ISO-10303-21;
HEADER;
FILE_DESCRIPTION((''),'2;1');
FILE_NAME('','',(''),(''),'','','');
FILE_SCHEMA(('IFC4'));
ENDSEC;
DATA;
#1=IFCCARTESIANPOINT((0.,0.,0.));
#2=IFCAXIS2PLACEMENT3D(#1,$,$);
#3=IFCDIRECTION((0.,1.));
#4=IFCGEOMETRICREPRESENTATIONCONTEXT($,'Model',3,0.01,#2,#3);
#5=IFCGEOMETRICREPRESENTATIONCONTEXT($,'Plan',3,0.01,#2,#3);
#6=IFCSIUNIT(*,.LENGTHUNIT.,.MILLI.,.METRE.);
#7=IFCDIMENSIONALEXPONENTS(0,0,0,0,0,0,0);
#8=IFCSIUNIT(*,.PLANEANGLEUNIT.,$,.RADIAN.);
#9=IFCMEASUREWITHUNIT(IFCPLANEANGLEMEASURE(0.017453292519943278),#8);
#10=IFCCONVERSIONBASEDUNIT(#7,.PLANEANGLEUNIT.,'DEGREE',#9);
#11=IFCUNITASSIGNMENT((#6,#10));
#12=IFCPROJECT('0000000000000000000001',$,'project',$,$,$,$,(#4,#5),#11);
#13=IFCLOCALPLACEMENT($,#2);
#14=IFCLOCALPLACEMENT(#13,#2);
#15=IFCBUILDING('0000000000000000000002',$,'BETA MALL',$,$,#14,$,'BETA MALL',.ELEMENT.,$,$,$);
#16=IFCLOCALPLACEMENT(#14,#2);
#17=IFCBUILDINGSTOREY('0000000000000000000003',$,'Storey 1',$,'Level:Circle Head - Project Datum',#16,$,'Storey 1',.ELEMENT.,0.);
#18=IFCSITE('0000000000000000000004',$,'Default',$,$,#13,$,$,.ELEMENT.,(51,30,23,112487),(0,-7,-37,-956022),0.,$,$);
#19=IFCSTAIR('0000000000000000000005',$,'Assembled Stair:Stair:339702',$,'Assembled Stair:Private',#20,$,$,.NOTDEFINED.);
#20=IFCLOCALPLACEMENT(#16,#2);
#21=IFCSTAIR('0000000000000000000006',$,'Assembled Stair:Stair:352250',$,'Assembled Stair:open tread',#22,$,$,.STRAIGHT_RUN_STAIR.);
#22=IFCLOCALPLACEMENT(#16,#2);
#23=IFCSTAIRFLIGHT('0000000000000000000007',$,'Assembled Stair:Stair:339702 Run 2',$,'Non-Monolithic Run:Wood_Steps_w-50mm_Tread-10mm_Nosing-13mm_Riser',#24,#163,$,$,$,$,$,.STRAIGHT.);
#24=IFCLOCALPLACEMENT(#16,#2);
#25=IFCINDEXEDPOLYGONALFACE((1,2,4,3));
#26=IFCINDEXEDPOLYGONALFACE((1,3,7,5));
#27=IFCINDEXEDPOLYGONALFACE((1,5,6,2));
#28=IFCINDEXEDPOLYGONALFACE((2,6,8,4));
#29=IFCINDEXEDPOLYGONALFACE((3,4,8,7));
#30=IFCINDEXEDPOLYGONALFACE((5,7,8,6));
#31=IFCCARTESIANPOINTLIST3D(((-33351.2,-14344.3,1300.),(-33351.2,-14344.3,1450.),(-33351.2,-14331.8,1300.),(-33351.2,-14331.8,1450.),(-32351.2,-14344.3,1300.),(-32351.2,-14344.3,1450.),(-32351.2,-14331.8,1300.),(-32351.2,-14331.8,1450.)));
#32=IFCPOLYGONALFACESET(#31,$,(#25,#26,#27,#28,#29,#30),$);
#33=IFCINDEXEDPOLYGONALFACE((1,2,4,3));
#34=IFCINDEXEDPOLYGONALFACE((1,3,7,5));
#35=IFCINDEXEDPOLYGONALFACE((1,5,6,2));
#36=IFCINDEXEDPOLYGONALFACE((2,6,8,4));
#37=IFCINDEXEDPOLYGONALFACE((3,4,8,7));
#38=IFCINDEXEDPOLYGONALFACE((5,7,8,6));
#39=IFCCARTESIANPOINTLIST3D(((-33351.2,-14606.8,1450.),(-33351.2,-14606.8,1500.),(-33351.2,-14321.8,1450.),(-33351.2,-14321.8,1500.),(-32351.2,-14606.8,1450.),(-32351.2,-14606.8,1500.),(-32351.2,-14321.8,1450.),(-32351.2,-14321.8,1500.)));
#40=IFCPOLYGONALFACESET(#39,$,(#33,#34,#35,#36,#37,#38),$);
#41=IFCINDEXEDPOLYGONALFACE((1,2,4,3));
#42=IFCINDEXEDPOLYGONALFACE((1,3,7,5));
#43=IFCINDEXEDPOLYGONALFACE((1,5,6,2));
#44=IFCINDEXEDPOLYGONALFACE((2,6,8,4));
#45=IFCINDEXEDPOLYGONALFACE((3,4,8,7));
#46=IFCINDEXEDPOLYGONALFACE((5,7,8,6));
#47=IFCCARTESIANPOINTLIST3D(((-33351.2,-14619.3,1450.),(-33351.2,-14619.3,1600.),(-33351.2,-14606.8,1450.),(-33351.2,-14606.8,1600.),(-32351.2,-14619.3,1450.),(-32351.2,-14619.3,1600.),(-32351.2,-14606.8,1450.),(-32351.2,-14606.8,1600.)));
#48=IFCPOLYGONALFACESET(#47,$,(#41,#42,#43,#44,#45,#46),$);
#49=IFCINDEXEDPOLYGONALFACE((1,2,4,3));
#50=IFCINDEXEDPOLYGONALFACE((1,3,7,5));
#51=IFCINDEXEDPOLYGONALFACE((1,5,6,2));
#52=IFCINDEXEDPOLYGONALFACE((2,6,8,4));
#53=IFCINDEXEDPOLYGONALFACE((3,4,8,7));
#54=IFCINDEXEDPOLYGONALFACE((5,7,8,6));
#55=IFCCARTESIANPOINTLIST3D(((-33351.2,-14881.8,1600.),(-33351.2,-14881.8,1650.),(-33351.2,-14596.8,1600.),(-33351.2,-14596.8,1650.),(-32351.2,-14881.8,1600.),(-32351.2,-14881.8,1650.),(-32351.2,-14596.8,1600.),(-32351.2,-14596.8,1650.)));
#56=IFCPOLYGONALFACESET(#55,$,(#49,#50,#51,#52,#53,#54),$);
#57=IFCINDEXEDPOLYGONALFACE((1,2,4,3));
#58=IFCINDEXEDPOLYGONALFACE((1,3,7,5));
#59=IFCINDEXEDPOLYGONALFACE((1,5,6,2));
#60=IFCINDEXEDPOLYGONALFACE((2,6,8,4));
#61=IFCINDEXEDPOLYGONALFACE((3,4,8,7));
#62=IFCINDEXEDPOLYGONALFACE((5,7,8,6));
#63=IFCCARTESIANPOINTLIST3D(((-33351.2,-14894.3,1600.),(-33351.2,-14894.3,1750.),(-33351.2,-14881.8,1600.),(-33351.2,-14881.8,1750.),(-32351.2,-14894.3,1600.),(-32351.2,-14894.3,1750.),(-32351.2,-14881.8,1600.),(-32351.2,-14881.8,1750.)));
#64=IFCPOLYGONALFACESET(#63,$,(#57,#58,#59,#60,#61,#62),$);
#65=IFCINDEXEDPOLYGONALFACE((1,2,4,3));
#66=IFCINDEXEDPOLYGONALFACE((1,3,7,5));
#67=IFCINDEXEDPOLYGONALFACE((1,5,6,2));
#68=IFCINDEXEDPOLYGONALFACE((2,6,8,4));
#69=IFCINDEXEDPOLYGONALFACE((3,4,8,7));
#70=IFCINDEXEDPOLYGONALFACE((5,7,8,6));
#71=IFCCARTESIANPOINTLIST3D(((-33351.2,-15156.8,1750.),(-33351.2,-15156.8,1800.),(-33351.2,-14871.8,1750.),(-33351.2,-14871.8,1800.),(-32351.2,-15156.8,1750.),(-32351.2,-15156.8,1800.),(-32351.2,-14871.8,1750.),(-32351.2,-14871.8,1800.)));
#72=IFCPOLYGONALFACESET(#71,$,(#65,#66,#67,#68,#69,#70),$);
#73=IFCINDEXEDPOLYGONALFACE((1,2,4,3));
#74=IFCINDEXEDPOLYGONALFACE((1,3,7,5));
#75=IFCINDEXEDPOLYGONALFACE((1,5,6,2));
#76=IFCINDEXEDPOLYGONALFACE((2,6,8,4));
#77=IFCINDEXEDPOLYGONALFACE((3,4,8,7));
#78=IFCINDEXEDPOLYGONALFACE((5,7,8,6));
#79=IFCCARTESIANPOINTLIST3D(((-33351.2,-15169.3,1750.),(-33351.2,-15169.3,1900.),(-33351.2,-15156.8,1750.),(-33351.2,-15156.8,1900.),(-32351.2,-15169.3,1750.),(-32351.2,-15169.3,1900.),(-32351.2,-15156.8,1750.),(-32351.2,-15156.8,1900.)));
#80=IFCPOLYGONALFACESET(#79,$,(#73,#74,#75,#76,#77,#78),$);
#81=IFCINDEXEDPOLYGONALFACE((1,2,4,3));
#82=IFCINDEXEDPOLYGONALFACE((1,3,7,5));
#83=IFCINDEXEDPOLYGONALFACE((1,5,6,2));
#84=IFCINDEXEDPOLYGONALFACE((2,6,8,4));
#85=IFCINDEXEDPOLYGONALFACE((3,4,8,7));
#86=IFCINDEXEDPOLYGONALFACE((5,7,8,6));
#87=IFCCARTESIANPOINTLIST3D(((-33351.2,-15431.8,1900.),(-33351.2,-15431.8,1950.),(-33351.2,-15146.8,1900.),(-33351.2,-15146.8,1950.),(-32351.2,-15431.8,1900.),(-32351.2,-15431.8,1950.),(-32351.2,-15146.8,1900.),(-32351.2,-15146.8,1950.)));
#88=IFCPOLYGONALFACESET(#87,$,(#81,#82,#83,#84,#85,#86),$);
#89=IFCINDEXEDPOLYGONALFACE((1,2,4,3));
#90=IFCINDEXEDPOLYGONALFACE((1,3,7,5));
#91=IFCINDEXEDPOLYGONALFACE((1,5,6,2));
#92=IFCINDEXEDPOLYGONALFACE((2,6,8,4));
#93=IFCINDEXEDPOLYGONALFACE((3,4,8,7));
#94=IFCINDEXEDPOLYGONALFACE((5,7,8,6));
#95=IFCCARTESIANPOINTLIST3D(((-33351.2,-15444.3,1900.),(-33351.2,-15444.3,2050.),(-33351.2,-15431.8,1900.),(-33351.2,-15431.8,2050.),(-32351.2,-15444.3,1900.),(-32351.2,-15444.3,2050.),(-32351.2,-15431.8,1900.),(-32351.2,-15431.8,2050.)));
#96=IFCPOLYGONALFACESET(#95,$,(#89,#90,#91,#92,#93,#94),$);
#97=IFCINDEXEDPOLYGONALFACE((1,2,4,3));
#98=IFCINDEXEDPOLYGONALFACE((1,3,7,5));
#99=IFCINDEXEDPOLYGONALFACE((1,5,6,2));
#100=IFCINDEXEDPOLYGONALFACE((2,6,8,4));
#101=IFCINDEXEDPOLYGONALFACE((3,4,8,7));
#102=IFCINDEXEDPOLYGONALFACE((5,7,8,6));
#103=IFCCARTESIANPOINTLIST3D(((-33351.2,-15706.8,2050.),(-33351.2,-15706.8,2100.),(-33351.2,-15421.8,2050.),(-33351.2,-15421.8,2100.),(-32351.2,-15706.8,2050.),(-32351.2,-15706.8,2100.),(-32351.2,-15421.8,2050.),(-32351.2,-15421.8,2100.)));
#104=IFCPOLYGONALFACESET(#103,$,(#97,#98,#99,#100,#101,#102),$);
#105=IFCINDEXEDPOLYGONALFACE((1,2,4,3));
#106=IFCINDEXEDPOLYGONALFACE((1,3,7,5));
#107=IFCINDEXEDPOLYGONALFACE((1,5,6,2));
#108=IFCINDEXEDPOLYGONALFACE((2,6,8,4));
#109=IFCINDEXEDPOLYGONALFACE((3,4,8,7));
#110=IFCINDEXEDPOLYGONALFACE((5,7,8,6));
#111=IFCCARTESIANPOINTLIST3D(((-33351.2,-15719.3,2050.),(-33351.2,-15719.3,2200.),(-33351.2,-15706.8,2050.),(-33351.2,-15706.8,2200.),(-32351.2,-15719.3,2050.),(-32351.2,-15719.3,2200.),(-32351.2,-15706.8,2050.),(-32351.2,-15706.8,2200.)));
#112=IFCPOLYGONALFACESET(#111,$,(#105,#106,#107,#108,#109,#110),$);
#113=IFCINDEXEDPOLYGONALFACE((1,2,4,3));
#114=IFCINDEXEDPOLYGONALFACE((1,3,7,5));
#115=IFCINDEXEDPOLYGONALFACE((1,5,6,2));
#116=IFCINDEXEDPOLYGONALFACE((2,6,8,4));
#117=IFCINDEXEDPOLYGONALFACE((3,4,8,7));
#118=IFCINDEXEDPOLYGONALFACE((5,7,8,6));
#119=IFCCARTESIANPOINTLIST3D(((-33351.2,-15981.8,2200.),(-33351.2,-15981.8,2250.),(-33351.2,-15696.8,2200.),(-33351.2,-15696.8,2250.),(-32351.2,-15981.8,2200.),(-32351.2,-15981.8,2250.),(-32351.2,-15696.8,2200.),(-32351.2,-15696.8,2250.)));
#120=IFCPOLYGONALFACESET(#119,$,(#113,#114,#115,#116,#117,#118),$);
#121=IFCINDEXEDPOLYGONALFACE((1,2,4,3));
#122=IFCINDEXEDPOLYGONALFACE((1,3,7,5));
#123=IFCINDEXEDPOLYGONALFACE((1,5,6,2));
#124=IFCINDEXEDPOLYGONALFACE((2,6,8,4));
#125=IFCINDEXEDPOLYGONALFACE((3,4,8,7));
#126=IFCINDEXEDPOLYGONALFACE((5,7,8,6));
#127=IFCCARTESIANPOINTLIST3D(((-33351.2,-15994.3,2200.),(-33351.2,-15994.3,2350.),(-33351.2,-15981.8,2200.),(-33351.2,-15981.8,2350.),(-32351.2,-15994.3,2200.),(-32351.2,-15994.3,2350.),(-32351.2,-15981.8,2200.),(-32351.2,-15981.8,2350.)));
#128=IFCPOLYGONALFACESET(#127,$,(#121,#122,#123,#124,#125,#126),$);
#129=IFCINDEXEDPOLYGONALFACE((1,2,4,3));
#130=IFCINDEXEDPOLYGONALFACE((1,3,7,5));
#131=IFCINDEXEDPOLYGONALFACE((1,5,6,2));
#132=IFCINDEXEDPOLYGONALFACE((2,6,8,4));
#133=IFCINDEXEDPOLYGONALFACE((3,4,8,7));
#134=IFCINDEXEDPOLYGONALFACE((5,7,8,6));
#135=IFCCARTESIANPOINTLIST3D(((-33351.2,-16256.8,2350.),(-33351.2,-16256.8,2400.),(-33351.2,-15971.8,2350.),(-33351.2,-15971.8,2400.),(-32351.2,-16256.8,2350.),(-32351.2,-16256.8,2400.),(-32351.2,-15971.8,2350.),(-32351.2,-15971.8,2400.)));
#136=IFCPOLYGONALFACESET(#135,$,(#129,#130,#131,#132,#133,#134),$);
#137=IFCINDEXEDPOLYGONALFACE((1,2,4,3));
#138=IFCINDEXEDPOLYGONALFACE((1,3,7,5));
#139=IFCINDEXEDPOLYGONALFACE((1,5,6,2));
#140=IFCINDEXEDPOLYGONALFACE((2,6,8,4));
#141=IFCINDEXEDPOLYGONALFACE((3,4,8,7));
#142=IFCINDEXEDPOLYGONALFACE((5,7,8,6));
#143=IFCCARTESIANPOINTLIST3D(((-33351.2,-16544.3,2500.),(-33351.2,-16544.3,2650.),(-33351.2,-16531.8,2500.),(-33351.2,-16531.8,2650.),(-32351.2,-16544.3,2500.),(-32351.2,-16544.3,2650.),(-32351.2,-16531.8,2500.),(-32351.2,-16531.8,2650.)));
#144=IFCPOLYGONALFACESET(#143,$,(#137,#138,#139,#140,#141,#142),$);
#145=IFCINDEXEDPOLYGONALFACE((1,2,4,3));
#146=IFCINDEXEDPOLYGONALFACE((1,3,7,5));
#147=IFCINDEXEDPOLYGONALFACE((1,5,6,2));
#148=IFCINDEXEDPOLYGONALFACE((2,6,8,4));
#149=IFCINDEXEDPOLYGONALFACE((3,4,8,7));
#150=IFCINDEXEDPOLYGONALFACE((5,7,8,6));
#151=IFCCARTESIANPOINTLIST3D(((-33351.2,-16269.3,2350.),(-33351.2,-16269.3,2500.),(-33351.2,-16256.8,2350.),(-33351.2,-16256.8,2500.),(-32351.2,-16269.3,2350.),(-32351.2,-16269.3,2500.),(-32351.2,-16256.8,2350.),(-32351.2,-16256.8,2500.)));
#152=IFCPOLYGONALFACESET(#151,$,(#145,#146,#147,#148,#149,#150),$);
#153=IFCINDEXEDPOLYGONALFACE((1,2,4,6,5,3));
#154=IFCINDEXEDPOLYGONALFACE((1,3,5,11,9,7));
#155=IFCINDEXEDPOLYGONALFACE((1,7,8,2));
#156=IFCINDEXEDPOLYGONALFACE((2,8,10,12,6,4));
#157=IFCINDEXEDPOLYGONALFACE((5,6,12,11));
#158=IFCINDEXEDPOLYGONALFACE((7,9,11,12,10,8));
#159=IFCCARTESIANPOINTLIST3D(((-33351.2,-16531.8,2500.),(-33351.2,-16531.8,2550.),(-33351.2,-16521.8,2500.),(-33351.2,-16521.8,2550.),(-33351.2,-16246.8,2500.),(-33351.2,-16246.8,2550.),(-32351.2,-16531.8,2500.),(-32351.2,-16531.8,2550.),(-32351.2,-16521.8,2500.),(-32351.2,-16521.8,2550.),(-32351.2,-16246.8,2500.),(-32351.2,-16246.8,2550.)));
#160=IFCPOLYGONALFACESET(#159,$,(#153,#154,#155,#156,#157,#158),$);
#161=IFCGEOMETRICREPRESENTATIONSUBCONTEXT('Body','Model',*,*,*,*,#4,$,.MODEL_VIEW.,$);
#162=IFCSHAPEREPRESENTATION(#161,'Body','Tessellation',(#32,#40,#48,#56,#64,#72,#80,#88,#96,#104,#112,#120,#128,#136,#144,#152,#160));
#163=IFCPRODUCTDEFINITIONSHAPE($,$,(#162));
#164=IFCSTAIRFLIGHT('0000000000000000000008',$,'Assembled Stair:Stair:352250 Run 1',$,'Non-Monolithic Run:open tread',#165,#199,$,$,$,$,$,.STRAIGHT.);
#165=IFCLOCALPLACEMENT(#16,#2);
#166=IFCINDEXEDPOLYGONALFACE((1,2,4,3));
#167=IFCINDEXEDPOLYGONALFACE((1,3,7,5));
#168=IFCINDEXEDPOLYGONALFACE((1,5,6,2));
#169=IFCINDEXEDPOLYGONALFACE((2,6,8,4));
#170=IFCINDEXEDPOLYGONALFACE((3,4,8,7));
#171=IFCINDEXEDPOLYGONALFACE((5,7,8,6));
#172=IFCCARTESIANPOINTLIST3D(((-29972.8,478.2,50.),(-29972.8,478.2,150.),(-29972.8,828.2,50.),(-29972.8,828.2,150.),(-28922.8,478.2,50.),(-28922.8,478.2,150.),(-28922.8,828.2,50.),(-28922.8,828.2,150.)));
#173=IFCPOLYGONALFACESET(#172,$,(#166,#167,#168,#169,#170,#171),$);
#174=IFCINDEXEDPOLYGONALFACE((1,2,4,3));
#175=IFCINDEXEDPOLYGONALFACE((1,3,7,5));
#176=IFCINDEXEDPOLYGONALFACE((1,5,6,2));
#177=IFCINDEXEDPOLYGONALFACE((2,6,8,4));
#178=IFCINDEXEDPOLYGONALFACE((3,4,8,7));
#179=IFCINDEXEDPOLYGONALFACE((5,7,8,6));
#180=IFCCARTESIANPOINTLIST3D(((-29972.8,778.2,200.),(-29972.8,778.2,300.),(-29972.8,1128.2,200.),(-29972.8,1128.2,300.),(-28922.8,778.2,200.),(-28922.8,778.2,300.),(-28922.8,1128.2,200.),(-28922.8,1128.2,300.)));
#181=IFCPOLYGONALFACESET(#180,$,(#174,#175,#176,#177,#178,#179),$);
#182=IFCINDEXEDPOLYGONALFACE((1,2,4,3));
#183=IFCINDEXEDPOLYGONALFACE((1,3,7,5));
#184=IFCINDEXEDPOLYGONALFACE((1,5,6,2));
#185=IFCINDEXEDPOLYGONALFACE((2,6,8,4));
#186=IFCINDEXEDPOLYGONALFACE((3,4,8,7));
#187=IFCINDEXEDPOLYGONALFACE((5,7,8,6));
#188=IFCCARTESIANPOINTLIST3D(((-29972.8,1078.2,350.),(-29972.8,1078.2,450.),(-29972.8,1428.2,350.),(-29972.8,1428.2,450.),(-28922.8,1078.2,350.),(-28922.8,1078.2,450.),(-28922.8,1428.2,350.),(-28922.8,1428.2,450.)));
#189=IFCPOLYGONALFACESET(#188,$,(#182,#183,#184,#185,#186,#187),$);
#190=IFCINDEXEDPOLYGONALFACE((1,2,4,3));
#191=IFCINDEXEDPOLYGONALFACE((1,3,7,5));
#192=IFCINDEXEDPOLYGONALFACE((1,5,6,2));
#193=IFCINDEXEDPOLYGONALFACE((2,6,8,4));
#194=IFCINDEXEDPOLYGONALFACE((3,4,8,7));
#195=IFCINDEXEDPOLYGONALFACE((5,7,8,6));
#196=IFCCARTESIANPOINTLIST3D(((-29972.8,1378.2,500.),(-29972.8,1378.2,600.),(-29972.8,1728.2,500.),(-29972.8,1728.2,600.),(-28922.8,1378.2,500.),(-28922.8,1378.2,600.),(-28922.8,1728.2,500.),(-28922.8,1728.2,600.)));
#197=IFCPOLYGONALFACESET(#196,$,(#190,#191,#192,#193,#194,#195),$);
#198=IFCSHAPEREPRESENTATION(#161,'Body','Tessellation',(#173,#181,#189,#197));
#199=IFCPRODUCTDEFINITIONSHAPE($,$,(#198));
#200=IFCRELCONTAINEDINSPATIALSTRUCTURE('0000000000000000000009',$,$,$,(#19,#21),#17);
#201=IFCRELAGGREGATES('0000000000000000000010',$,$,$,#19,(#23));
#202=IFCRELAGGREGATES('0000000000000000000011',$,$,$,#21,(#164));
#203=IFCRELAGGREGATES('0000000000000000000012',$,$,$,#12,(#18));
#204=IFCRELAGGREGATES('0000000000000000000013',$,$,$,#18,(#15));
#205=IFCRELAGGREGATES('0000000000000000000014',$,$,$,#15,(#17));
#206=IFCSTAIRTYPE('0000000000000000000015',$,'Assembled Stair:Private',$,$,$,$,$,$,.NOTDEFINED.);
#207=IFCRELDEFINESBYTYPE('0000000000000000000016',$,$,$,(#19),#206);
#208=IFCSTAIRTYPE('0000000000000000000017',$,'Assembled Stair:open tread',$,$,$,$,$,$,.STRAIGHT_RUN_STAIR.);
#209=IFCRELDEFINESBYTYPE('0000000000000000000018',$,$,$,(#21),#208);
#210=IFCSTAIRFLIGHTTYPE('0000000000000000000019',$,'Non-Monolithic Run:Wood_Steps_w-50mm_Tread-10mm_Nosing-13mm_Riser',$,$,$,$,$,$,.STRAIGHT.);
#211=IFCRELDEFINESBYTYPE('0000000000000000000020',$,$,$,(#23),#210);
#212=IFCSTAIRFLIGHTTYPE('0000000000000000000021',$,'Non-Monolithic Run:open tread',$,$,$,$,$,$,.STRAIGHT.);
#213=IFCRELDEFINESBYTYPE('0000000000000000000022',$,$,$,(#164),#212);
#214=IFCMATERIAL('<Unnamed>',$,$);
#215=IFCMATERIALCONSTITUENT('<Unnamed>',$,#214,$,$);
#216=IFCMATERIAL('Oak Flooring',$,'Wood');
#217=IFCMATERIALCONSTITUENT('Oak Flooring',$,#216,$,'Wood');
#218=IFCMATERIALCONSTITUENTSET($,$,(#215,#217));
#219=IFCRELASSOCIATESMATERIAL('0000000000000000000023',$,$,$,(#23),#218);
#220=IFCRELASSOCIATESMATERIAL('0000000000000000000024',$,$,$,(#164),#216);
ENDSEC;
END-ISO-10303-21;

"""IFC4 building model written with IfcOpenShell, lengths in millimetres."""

from ifc_helpers import new_model, entity, si_unit, converted_unit, direction, frame, origin, place, context, subcontext, project, spatial, indexed_curve, outline, extrude, material, constituent, constituent_set, type_object, element, aggregate, save


model = new_model("IFC4")

# Units and contexts
model_context = context("Model", 3, precision=0.01, world=origin(), true_north=direction((0.0, 1.0)))
plan_context = context("Plan", 3, precision=0.01, world=origin(), true_north=direction((0.0, 1.0)))
body_context = subcontext(model_context, "Body", "Model", "MODEL_VIEW")
ifc_project = project(units=[si_unit("LENGTHUNIT", "METRE", prefix="MILLI"), converted_unit("PLANEANGLEUNIT", "DEGREE", entity("IfcPlaneAngleMeasure", 0.017453292519943278), si_unit("PLANEANGLEUNIT", "RADIAN"), dimensions=[0, 0, 0, 0, 0, 0, 0])], contexts=[model_context, plan_context])

# Site, building, storey
site_placement = place(None, origin())
site = spatial("IfcSite", under=ifc_project, at=site_placement, Name="Default", CompositionType="ELEMENT", RefLatitude=(51, 30, 23, 112487), RefLongitude=(0, -7, -37, -956022), RefElevation=0.0)
building_placement = place(site_placement, origin())
building = spatial("IfcBuilding", under=site, at=building_placement, Name="BETA MALL", LongName="BETA MALL", CompositionType="ELEMENT")
storey_placement = place(building_placement, origin())
storey = spatial("IfcBuildingStorey", under=building, at=storey_placement, Name="Storey 1", ObjectType="Level:Circle Head - Project Datum", LongName="Storey 1", CompositionType="ELEMENT", Elevation=0.0)

# Shared definitions
ifc_material_1 = material(Name="<Unnamed>")

# Stair
stair_type_1 = type_object("IfcStairType", Name="Assembled Stair:Private", PredefinedType="NOTDEFINED")
stair_1_placement = place(storey_placement, origin())
stair_1 = element("IfcStair", 1, at=stair_1_placement, inside=storey, type_object=stair_type_1, Name="Assembled Stair:Stair:339702", ObjectType="Assembled Stair:Private", PredefinedType="NOTDEFINED")
ifc_material_2 = material(Name="Oak Flooring", Category="Wood")

# Stair
stair_type_2 = type_object("IfcStairType", Name="Assembled Stair:open tread", PredefinedType="STRAIGHT_RUN_STAIR")
stair_2_placement = place(storey_placement, origin())
stair_2 = element("IfcStair", 2, at=stair_2_placement, inside=storey, type_object=stair_type_2, Name="Assembled Stair:Stair:352250", ObjectType="Assembled Stair:open tread", PredefinedType="STRAIGHT_RUN_STAIR")

# Stair flights
stair_flight_type_1 = type_object("IfcStairFlightType", Name="Non-Monolithic Run:Wood_Steps_w-50mm_Tread-10mm_Nosing-13mm_Riser", PredefinedType="STRAIGHT")
ifc_constituent_1 = constituent(ifc_material_1, Name="<Unnamed>")
ifc_constituent_2 = constituent(ifc_material_2, Name="Oak Flooring", Category="Wood")
ifc_constituent_set_1 = constituent_set(constituents=[ifc_constituent_1, ifc_constituent_2])
stair_flight_1_placement = place(stair_1_placement, origin())
stair_flight_1 = element("IfcStairFlight", 3, at=stair_flight_1_placement, type_object=stair_flight_type_1, material=ifc_constituent_set_1, Name="Assembled Stair:Stair:339702 Run 2", ObjectType="Non-Monolithic Run:Wood_Steps_w-50mm_Tread-10mm_Nosing-13mm_Riser", PredefinedType="STRAIGHT", context=body_context, shape_type="SweptSolid", body=[
    extrude(outline(indexed_curve([(-500.0, -6.2), (500.0, -6.2), (500.0, 6.3), (-500.0, 6.3), (-500.0, -6.2)], self_intersect=False)), frame((-32851.2, -14338.1, 1300.0)), (0.0, 0.0, 1.0), 150.0),
    extrude(outline(indexed_curve([(-142.5, -500.0), (142.5, -500.0), (142.5, 500.0), (-142.5, 500.0), (-142.5, -500.0)], self_intersect=False)), frame((-32851.2, -14464.3, 1450.0), z_axis=(0.0, 0.0, 1.0), x_axis=(0.0, 1.0, 0.0)), (0.0, 0.0, 1.0), 50.0),
    extrude(outline(indexed_curve([(-500.0, -6.3), (500.0, -6.3), (500.0, 6.2), (-500.0, 6.2), (-500.0, -6.3)], self_intersect=False)), frame((-32851.2, -14613.1, 1450.0)), (0.0, 0.0, 1.0), 150.0),
    extrude(outline(indexed_curve([(-142.5, -500.0), (142.5, -500.0), (142.5, 500.0), (-142.5, 500.0), (-142.5, -500.0)], self_intersect=False)), frame((-32851.2, -14739.3, 1600.0), z_axis=(0.0, 0.0, 1.0), x_axis=(0.0, 1.0, 0.0)), (0.0, 0.0, 1.0), 50.0),
    extrude(outline(indexed_curve([(-500.0, -6.3), (500.0, -6.3), (500.0, 6.2), (-500.0, 6.2), (-500.0, -6.3)], self_intersect=False)), frame((-32851.2, -14888.1, 1600.0)), (0.0, 0.0, 1.0), 150.0),
    extrude(outline(indexed_curve([(-142.5, -500.0), (142.5, -500.0), (142.5, 500.0), (-142.5, 500.0), (-142.5, -500.0)], self_intersect=False)), frame((-32851.2, -15014.3, 1750.0), z_axis=(0.0, 0.0, 1.0), x_axis=(0.0, 1.0, 0.0)), (0.0, 0.0, 1.0), 50.0),
    extrude(outline(indexed_curve([(-500.0, -6.3), (500.0, -6.3), (500.0, 6.2), (-500.0, 6.2), (-500.0, -6.3)], self_intersect=False)), frame((-32851.2, -15163.1, 1750.0)), (0.0, 0.0, 1.0), 150.0),
    extrude(outline(indexed_curve([(-142.5, -500.0), (142.5, -500.0), (142.5, 500.0), (-142.5, 500.0), (-142.5, -500.0)], self_intersect=False)), frame((-32851.2, -15289.3, 1900.0), z_axis=(0.0, 0.0, 1.0), x_axis=(0.0, 1.0, 0.0)), (0.0, 0.0, 1.0), 50.0),
    extrude(outline(indexed_curve([(-500.0, -6.2), (500.0, -6.2), (500.0, 6.3), (-500.0, 6.3), (-500.0, -6.2)], self_intersect=False)), frame((-32851.2, -15438.1, 1900.0)), (0.0, 0.0, 1.0), 150.0),
    extrude(outline(indexed_curve([(-142.5, -500.0), (142.5, -500.0), (142.5, 500.0), (-142.5, 500.0), (-142.5, -500.0)], self_intersect=False)), frame((-32851.2, -15564.3, 2050.0), z_axis=(0.0, 0.0, 1.0), x_axis=(0.0, 1.0, 0.0)), (0.0, 0.0, 1.0), 50.0),
    extrude(outline(indexed_curve([(-500.0, -6.2), (500.0, -6.2), (500.0, 6.3), (-500.0, 6.3), (-500.0, -6.2)], self_intersect=False)), frame((-32851.2, -15713.1, 2050.0)), (0.0, 0.0, 1.0), 150.0),
    extrude(outline(indexed_curve([(-142.5, -500.0), (142.5, -500.0), (142.5, 500.0), (-142.5, 500.0), (-142.5, -500.0)], self_intersect=False)), frame((-32851.2, -15839.3, 2200.0), z_axis=(0.0, 0.0, 1.0), x_axis=(0.0, 1.0, 0.0)), (0.0, 0.0, 1.0), 50.0),
    extrude(outline(indexed_curve([(-500.0, -6.3), (500.0, -6.3), (500.0, 6.2), (-500.0, 6.2), (-500.0, -6.3)], self_intersect=False)), frame((-32851.2, -15988.1, 2200.0)), (0.0, 0.0, 1.0), 150.0),
    extrude(outline(indexed_curve([(-142.5, -500.0), (142.5, -500.0), (142.5, 500.0), (-142.5, 500.0), (-142.5, -500.0)], self_intersect=False)), frame((-32851.2, -16114.3, 2350.0), z_axis=(0.0, 0.0, 1.0), x_axis=(0.0, 1.0, 0.0)), (0.0, 0.0, 1.0), 50.0),
    extrude(outline(indexed_curve([(-500.0, -6.2), (500.0, -6.2), (500.0, 6.3), (-500.0, 6.3), (-500.0, -6.2)], self_intersect=False)), frame((-32851.2, -16538.1, 2500.0)), (0.0, 0.0, 1.0), 150.0),
    extrude(outline(indexed_curve([(-500.0, -6.3), (500.0, -6.3), (500.0, 6.2), (-500.0, 6.2), (-500.0, -6.3)], self_intersect=False)), frame((-32851.2, -16263.1, 2350.0)), (0.0, 0.0, 1.0), 150.0),
    extrude(outline(indexed_curve([(-98.3, -500.0), (-88.3, -500.0), (186.7, -500.0), (186.7, 500.0), (-88.3, 500.0), (-98.3, 500.0), (-98.3, -500.0)], self_intersect=False)), frame((-32851.2, -16433.5, 2500.0), z_axis=(0.0, 0.0, 1.0), x_axis=(0.0, 1.0, 0.0)), (0.0, 0.0, 1.0), 50.0),
])
aggregate(stair_1, [stair_flight_1])
stair_flight_type_2 = type_object("IfcStairFlightType", Name="Non-Monolithic Run:open tread", PredefinedType="STRAIGHT")
stair_flight_2_placement = place(stair_2_placement, origin())
stair_flight_2 = element("IfcStairFlight", 4, at=stair_flight_2_placement, type_object=stair_flight_type_2, material=ifc_material_2, Name="Assembled Stair:Stair:352250 Run 1", ObjectType="Non-Monolithic Run:open tread", PredefinedType="STRAIGHT", context=body_context, shape_type="SweptSolid", body=[
    extrude(outline(indexed_curve([(-525.0, -175.0), (525.0, -175.0), (525.0, 175.0), (-525.0, 175.0), (-525.0, -175.0)], self_intersect=False)), frame((-29447.8, 653.2, 50.0), z_axis=(0.0, 0.0, 1.0), x_axis=(-1.0, 0.0, 0.0)), (0.0, 0.0, 1.0), 100.0),
    extrude(outline(indexed_curve([(-525.0, -175.0), (525.0, -175.0), (525.0, 175.0), (-525.0, 175.0), (-525.0, -175.0)], self_intersect=False)), frame((-29447.8, 953.2, 200.0), z_axis=(0.0, 0.0, 1.0), x_axis=(-1.0, 0.0, 0.0)), (0.0, 0.0, 1.0), 100.0),
    extrude(outline(indexed_curve([(-525.0, -175.0), (525.0, -175.0), (525.0, 175.0), (-525.0, 175.0), (-525.0, -175.0)], self_intersect=False)), frame((-29447.8, 1253.2, 350.0), z_axis=(0.0, 0.0, 1.0), x_axis=(-1.0, 0.0, 0.0)), (0.0, 0.0, 1.0), 100.0),
    extrude(outline(indexed_curve([(-525.0, -175.0), (525.0, -175.0), (525.0, 175.0), (-525.0, 175.0), (-525.0, -175.0)], self_intersect=False)), frame((-29447.8, 1553.2, 500.0), z_axis=(0.0, 0.0, 1.0), x_axis=(-1.0, 0.0, 0.0)), (0.0, 0.0, 1.0), 100.0),
])
aggregate(stair_2, [stair_flight_2])

save(model, "model.ifc")
